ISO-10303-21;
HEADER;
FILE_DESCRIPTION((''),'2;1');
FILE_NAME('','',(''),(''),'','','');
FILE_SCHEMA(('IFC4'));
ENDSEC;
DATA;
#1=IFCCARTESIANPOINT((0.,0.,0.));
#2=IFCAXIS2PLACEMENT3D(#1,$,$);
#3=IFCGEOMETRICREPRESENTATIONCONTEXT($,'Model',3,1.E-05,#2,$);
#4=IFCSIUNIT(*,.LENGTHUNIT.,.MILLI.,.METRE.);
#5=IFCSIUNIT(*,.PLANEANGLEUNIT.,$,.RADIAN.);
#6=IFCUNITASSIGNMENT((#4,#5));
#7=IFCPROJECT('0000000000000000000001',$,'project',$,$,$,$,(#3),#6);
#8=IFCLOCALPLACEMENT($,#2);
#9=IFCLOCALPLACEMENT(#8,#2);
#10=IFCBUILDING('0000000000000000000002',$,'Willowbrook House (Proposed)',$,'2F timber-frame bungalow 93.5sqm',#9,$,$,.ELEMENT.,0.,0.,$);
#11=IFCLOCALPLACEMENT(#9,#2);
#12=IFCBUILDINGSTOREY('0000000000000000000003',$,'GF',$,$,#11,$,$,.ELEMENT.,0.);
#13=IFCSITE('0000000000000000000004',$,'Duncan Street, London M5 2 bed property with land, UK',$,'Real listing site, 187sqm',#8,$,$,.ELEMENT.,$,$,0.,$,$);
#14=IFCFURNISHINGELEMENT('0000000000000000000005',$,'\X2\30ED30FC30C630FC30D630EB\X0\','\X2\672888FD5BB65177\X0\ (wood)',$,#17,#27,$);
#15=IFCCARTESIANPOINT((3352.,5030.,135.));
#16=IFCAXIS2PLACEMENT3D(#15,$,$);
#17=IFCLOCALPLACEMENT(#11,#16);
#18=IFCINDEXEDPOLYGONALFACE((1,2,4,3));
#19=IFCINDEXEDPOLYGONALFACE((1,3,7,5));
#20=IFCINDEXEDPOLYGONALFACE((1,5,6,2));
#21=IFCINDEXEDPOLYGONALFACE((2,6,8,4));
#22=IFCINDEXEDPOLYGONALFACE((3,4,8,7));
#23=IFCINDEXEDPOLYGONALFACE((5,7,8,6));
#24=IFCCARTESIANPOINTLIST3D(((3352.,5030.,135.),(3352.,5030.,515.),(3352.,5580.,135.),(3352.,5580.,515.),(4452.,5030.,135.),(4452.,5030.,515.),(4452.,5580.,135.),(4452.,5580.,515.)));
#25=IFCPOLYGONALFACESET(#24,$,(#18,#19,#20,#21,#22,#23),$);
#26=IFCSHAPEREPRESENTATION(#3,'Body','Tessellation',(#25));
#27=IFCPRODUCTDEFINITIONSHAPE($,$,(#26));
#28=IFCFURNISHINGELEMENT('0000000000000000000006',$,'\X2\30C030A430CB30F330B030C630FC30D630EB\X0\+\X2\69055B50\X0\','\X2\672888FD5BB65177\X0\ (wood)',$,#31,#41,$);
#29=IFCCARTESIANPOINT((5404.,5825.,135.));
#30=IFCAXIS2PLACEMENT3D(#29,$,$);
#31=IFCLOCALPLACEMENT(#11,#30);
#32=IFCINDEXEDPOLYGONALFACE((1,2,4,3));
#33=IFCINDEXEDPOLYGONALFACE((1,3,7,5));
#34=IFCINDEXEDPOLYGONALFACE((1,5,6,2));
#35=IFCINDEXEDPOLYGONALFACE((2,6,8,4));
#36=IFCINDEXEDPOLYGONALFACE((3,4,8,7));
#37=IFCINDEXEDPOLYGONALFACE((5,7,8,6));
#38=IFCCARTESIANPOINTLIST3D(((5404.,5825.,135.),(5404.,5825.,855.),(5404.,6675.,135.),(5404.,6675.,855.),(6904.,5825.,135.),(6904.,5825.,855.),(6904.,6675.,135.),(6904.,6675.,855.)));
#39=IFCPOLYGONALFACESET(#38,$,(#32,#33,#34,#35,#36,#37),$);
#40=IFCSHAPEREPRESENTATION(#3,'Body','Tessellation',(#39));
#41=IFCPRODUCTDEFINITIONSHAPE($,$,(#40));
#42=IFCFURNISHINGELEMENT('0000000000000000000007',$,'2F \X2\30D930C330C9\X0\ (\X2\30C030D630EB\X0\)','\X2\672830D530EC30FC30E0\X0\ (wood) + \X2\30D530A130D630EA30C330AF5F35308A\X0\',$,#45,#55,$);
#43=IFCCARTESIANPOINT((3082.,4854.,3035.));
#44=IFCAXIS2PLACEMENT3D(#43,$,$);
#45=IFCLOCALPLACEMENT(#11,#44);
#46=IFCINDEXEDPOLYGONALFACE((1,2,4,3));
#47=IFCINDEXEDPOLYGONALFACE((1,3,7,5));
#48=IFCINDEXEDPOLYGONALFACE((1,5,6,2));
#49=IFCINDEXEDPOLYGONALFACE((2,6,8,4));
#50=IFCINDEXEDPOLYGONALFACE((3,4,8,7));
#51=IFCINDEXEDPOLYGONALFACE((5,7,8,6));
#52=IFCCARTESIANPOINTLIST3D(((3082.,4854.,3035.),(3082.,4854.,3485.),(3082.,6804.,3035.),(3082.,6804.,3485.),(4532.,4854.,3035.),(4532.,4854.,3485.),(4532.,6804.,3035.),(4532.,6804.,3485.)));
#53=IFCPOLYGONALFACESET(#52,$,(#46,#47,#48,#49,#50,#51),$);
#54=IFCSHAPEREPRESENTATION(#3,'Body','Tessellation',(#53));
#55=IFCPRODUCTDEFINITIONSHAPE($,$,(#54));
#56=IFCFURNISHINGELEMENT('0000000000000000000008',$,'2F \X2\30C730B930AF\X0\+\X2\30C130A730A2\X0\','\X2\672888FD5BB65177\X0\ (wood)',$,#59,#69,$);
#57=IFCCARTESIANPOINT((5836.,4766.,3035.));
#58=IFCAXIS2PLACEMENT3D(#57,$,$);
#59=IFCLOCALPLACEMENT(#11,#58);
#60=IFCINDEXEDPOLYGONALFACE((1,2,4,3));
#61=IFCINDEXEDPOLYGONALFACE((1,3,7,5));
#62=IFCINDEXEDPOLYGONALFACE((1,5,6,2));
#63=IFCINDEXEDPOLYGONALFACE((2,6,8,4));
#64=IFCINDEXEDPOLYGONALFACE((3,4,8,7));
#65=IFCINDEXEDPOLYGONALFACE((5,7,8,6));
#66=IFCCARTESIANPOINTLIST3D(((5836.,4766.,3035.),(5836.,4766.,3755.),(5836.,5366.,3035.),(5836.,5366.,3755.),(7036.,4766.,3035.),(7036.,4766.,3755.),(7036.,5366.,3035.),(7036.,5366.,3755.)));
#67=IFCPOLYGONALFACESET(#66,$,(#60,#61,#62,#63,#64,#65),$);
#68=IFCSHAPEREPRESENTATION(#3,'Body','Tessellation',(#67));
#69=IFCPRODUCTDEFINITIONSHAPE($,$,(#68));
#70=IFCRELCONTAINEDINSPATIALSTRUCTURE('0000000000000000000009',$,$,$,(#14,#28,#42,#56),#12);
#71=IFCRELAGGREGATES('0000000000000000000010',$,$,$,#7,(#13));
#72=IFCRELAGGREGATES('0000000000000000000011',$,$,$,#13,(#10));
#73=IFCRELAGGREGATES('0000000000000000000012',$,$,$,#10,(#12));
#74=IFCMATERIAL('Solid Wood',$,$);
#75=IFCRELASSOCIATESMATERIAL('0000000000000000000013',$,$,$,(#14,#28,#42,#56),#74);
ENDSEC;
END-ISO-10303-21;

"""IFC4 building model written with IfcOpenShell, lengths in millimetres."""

from ifc_helpers import new_model, si_unit, frame, frame_2d, origin, place, context, project, spatial, rectangle, extrude, material, element, save


model = new_model("IFC4")

# Units and contexts
model_context = context("Model", 3, precision=1e-05, world=origin())
ifc_project = project(units=[si_unit("LENGTHUNIT", "METRE", prefix="MILLI"), si_unit("PLANEANGLEUNIT", "RADIAN")], contexts=[model_context])

# Site, building, storey
site_placement = place(None, origin())
site = spatial("IfcSite", under=ifc_project, at=site_placement, Name="Duncan Street, London M5 2 bed property with land, UK", ObjectType="Real listing site, 187sqm", CompositionType="ELEMENT", RefElevation=0.0)
building_placement = place(site_placement, origin())
building = spatial("IfcBuilding", under=site, at=building_placement, Name="Willowbrook House (Proposed)", ObjectType="2F timber-frame bungalow 93.5sqm", CompositionType="ELEMENT", ElevationOfRefHeight=0.0, ElevationOfTerrain=0.0)
storey_placement = place(building_placement, origin())
storey = spatial("IfcBuildingStorey", under=building, at=storey_placement, Name="GF", CompositionType="ELEMENT", Elevation=0.0)

# Shared definitions
ifc_material_1 = material(Name="Solid Wood")

# Furnishing elements
furnishing_1_placement = place(storey_placement, frame((3352.0, 5030.0, 135.0)))
element("IfcFurnishingElement", 1, at=furnishing_1_placement, inside=storey, material=ifc_material_1, Name="ローテーブル", Description="木製家具 (wood)", context=model_context, shape_type="SweptSolid", body=[
    extrude(rectangle(XDim=1100.0, YDim=550.0, at=frame_2d((550.0, 275.0))), frame((3352.0, 5030.0, 135.0)), (0.0, 0.0, 1.0), 380.0),
])
furnishing_2_placement = place(storey_placement, frame((5404.0, 5825.0, 135.0)))
element("IfcFurnishingElement", 2, at=furnishing_2_placement, inside=storey, material=ifc_material_1, Name="ダイニングテーブル+椅子", Description="木製家具 (wood)", context=model_context, shape_type="SweptSolid", body=[
    extrude(rectangle(XDim=1500.0, YDim=850.0, at=frame_2d((750.0, 425.0))), frame((5404.0, 5825.0, 135.0)), (0.0, 0.0, 1.0), 720.0),
])
furnishing_3_placement = place(storey_placement, frame((3082.0, 4854.0, 3035.0)))
element("IfcFurnishingElement", 3, at=furnishing_3_placement, inside=storey, material=ifc_material_1, Name="2F ベッド (ダブル)", Description="木フレーム (wood) + ファブリック張り", context=model_context, shape_type="SweptSolid", body=[
    extrude(rectangle(XDim=1450.0, YDim=1950.0, at=frame_2d((725.0, 975.0))), frame((3082.0, 4854.0, 3035.0)), (0.0, 0.0, 1.0), 450.0),
])
furnishing_4_placement = place(storey_placement, frame((5836.0, 4766.0, 3035.0)))
element("IfcFurnishingElement", 4, at=furnishing_4_placement, inside=storey, material=ifc_material_1, Name="2F デスク+チェア", Description="木製家具 (wood)", context=model_context, shape_type="SweptSolid", body=[
    extrude(rectangle(XDim=1200.0, YDim=600.0, at=frame_2d((600.0, 300.0))), frame((5836.0, 4766.0, 3035.0)), (0.0, 0.0, 1.0), 720.0),
])

save(model, "model.ifc")
